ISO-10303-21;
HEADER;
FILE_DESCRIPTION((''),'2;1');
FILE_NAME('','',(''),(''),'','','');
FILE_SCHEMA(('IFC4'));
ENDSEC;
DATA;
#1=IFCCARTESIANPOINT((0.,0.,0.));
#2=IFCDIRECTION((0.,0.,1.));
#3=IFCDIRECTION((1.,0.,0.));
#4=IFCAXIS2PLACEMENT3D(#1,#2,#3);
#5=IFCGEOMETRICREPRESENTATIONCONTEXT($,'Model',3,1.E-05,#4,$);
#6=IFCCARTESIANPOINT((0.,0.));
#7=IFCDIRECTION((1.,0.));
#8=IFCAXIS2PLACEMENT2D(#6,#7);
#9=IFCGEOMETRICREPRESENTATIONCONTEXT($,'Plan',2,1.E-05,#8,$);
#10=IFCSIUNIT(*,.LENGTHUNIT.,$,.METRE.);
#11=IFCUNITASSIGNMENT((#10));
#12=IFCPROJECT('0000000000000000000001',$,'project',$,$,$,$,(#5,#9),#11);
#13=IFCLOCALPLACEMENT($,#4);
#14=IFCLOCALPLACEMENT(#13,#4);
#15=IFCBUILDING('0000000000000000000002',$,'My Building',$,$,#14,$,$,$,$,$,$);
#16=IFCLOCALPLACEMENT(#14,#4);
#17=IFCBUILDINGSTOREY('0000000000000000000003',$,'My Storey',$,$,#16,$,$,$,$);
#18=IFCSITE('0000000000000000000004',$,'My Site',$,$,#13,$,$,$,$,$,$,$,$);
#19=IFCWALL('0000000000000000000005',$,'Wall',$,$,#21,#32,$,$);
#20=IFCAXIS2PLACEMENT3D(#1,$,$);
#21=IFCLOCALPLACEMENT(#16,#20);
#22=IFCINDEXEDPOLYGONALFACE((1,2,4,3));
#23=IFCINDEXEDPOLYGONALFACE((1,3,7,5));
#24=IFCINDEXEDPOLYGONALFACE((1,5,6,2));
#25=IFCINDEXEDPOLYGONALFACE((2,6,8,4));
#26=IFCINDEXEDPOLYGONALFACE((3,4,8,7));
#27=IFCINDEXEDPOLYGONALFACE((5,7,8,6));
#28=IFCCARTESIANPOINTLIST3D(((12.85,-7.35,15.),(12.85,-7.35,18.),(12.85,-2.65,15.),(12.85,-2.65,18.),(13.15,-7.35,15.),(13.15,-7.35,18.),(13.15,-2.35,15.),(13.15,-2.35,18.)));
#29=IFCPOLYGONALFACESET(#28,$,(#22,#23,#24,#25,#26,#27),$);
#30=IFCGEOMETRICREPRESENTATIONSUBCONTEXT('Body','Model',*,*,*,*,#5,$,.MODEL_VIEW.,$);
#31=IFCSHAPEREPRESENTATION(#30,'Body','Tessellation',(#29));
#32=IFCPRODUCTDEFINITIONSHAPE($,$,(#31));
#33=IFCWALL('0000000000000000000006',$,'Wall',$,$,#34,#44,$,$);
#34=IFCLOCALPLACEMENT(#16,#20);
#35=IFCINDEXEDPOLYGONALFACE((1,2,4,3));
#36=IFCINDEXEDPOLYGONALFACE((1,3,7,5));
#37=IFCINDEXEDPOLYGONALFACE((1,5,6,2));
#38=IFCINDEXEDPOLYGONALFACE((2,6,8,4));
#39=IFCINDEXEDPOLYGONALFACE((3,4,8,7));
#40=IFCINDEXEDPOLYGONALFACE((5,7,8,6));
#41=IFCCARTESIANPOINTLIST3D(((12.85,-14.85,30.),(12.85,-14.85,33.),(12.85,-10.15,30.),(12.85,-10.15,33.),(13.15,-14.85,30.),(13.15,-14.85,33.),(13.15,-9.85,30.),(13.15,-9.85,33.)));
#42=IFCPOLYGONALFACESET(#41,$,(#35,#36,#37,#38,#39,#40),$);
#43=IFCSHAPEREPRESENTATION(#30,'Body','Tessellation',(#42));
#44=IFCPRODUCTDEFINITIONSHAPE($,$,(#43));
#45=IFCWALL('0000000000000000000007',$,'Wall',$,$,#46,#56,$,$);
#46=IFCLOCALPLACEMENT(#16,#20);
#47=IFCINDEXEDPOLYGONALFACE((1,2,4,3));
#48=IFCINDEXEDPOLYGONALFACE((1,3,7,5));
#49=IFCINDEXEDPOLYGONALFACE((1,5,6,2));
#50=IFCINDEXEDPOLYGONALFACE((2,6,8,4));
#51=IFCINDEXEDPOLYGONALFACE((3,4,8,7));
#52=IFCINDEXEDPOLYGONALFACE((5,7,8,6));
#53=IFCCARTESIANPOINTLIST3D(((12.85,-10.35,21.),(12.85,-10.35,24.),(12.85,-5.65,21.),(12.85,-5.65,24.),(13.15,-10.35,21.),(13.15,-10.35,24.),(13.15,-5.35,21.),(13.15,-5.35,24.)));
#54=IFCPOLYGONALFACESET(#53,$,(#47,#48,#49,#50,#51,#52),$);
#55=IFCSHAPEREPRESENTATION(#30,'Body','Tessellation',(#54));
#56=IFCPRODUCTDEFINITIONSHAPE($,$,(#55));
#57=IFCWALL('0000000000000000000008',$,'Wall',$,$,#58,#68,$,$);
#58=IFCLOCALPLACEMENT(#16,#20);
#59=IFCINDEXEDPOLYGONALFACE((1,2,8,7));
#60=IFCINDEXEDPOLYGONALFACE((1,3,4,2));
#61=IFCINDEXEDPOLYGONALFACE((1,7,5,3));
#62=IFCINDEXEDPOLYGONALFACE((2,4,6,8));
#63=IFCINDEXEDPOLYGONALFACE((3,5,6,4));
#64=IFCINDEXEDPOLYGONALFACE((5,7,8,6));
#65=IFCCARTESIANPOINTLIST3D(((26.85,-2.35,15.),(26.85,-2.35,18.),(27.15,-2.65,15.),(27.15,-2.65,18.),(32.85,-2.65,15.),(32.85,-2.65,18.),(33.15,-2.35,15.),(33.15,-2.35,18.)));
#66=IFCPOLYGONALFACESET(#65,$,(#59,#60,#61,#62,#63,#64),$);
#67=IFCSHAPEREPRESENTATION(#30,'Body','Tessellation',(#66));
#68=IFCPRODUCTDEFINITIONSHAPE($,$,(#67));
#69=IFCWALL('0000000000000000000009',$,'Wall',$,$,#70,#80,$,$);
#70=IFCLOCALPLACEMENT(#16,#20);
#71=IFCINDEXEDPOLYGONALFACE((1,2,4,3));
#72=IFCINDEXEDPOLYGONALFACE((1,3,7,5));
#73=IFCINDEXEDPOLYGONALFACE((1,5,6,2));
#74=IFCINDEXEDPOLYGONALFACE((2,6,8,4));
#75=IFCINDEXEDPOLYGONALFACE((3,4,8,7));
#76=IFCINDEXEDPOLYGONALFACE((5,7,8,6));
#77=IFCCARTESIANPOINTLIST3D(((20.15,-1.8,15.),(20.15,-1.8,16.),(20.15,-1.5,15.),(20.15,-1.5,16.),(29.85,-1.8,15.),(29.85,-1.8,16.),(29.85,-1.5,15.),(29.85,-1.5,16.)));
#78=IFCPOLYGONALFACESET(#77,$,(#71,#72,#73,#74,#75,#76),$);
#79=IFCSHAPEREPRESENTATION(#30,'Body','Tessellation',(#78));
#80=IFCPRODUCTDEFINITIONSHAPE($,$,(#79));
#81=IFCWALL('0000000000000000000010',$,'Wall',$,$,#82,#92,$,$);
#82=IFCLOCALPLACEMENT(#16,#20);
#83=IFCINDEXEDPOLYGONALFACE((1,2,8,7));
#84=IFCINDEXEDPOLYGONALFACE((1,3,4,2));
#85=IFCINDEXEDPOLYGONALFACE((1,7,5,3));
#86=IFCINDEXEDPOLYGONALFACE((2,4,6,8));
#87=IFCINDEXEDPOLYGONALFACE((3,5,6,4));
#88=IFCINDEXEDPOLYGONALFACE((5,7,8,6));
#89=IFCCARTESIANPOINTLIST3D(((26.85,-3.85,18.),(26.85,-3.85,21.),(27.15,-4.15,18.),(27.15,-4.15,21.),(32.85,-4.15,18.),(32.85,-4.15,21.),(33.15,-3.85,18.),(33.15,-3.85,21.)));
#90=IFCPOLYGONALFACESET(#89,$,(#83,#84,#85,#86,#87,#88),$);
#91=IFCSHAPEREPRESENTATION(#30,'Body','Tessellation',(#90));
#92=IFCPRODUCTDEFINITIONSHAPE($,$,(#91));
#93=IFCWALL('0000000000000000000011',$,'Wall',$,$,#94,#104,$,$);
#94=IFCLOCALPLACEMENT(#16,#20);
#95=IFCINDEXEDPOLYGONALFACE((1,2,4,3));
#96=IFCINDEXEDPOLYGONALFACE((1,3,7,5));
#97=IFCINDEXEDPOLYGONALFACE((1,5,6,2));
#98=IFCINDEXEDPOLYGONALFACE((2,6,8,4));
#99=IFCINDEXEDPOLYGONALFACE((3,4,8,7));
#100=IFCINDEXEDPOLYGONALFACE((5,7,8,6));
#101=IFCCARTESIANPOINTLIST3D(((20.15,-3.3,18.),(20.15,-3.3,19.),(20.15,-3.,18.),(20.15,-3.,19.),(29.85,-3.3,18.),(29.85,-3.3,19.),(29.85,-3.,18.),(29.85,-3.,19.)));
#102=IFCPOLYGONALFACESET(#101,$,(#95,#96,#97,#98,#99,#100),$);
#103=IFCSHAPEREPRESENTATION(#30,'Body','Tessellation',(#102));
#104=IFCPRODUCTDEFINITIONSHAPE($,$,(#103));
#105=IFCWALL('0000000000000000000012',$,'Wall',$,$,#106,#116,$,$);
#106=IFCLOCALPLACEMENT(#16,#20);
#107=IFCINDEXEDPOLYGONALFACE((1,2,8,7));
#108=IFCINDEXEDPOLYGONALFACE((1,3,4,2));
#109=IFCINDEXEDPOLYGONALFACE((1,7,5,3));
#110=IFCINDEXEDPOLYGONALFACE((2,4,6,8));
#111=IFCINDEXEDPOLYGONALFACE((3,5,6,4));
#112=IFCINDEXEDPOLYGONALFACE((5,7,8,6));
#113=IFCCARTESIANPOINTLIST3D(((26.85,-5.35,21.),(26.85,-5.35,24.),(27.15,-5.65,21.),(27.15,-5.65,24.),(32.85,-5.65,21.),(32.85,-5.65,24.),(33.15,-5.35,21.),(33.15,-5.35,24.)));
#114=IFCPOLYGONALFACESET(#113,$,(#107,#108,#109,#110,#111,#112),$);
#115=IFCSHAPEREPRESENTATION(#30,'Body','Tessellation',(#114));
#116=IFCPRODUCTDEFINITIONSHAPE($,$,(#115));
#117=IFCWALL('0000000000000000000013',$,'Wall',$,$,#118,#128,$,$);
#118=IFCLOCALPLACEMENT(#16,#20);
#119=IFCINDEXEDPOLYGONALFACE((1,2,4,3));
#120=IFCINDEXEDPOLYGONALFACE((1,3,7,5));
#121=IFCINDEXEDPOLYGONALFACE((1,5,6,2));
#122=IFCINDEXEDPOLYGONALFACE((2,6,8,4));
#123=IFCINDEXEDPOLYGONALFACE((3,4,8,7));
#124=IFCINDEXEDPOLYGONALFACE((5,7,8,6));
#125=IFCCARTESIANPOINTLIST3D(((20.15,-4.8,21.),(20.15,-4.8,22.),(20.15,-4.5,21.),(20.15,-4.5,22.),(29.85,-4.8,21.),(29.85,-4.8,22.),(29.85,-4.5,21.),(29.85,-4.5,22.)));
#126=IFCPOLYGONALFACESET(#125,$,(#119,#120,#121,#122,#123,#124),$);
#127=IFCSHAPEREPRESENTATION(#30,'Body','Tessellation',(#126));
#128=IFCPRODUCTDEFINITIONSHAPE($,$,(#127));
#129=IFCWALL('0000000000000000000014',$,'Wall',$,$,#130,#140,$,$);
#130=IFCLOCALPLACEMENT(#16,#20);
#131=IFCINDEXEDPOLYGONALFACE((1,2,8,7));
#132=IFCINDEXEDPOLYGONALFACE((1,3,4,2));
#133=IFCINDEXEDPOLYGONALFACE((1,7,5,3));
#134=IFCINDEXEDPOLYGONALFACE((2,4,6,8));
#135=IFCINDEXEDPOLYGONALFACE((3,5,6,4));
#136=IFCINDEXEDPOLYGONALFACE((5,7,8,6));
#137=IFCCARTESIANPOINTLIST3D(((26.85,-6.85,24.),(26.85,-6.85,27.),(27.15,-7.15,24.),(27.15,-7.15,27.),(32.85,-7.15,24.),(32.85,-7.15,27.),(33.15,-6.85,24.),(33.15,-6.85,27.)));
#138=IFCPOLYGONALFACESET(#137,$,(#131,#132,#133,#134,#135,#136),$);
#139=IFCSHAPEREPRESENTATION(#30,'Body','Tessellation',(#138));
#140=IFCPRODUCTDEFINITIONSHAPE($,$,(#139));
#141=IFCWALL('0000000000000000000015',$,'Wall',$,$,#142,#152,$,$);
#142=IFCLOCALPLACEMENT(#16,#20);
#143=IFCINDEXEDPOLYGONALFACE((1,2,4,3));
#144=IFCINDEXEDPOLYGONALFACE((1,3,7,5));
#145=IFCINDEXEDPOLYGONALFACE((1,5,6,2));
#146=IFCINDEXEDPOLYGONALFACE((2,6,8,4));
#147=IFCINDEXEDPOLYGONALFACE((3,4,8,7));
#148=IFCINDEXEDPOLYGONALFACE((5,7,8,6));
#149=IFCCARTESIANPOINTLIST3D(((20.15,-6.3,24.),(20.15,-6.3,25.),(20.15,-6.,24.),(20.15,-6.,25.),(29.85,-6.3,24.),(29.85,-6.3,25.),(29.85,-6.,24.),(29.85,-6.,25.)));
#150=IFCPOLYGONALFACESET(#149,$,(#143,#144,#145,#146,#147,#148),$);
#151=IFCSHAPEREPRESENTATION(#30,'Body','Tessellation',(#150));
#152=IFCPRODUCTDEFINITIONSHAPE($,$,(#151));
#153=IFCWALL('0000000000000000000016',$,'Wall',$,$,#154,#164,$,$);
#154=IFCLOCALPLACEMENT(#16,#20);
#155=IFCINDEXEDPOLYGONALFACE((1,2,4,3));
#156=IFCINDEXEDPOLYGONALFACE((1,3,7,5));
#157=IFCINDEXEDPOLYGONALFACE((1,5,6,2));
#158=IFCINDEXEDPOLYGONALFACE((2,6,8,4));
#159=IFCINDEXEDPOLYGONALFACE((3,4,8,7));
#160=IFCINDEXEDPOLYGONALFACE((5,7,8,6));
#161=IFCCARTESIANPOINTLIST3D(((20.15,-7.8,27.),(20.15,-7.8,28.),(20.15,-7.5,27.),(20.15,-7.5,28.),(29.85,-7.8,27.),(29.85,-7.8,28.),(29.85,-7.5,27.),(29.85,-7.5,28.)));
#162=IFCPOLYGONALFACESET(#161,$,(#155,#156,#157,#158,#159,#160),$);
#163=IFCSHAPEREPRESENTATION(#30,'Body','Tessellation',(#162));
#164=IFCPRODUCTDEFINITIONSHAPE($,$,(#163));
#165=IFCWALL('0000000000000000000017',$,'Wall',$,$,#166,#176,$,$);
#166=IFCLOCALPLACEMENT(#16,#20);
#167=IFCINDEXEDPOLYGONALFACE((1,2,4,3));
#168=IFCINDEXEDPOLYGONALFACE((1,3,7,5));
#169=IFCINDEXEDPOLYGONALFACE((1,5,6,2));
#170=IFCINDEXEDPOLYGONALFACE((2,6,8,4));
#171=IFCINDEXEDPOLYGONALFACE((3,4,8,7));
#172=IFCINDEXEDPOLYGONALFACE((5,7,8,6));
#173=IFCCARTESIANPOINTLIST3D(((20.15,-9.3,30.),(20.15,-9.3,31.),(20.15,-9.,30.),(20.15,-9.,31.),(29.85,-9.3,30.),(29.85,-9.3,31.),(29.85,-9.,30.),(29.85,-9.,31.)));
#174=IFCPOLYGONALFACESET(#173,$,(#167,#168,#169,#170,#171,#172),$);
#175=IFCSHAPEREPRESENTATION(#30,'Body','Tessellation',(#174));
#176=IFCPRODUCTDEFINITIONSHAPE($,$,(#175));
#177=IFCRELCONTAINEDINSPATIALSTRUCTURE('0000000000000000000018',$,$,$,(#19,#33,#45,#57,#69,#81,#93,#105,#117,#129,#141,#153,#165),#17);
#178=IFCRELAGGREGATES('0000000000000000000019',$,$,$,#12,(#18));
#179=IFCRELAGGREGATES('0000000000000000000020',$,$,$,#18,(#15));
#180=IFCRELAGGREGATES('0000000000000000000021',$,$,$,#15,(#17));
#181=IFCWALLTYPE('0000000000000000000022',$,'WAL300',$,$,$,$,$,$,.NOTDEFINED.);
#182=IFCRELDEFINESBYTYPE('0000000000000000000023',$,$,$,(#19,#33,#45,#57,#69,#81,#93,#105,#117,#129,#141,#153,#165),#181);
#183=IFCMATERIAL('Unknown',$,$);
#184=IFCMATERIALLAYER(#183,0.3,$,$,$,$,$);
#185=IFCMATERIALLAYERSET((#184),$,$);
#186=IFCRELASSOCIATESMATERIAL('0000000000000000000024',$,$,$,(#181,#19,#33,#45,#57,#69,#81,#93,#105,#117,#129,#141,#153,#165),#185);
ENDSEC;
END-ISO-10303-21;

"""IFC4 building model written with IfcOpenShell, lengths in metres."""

from ifc_helpers import new_model, si_unit, frame, origin_with_axes, origin_2d_with_axis, place, context, subcontext, project, spatial, line, indexed_curve, outline, extrude, material, layer, layer_set, layer_usage, type_object, element, save


model = new_model("IFC4")

# Units and contexts
model_context = context("Model", 3, precision=1e-05, world=origin_with_axes())
plan_context = context("Plan", 2, precision=1e-05, world=origin_2d_with_axis())
body_context = subcontext(model_context, "Body", "Model", "MODEL_VIEW")
ifc_project = project(units=[si_unit("LENGTHUNIT", "METRE")], contexts=[model_context, plan_context])

# Site, building, storey
site_placement = place(None, origin_with_axes())
site = spatial("IfcSite", under=ifc_project, at=site_placement, Name="My Site")
building_placement = place(site_placement, origin_with_axes())
building = spatial("IfcBuilding", under=site, at=building_placement, Name="My Building")
storey_placement = place(building_placement, origin_with_axes())
storey = spatial("IfcBuildingStorey", under=building, at=storey_placement, Name="My Storey")

# Walls
ifc_material = material(Name="Unknown")
ifc_layer = layer(ifc_material, 0.3)
ifc_layer_set = layer_set([ifc_layer])
wall_type = type_object("IfcWallType", Name="WAL300", PredefinedType="NOTDEFINED", material=ifc_layer_set)
ifc_layer_usage_1 = layer_usage(ifc_layer_set, "AXIS2", "POSITIVE", -0.15)
wall_1_placement = place(storey_placement, frame((13.0, -7.5, 15.0), z_axis=(0.0, 0.0, 1.0), x_axis=(0.0, 1.0, 0.0)))
element("IfcWall", 1, at=wall_1_placement, inside=storey, type_object=wall_type, material=ifc_layer_usage_1, Name="Wall", context=body_context, shape_type="SweptSolid", body=[
    extrude(outline(indexed_curve([(0.15, -0.15), (0.15, 0.15), (4.85, 0.15), (5.15, -0.15)], segments=[line(1, 2, 3, 4, 1)])), origin_with_axes(), (0.0, 0.0, 1.0), 3.0),
])
ifc_layer_usage_2 = layer_usage(ifc_layer_set, "AXIS2", "POSITIVE", -0.15)
wall_2_placement = place(storey_placement, frame((13.0, -15.0, 30.0), z_axis=(0.0, 0.0, 1.0), x_axis=(0.0, 1.0, 0.0)))
element("IfcWall", 2, at=wall_2_placement, inside=storey, type_object=wall_type, material=ifc_layer_usage_2, Name="Wall", context=body_context, shape_type="SweptSolid", body=[
    extrude(outline(indexed_curve([(0.15, -0.15), (0.15, 0.15), (4.85, 0.15), (5.15, -0.15)], segments=[line(1, 2, 3, 4, 1)])), origin_with_axes(), (0.0, 0.0, 1.0), 3.0),
])
ifc_layer_usage_3 = layer_usage(ifc_layer_set, "AXIS2", "POSITIVE", -0.15)
wall_3_placement = place(storey_placement, frame((13.0, -10.5, 21.0), z_axis=(0.0, 0.0, 1.0), x_axis=(0.0, 1.0, 0.0)))
element("IfcWall", 3, at=wall_3_placement, inside=storey, type_object=wall_type, material=ifc_layer_usage_3, Name="Wall", context=body_context, shape_type="SweptSolid", body=[
    extrude(outline(indexed_curve([(0.15, -0.15), (0.15, 0.15), (4.85, 0.15), (5.15, -0.15)], segments=[line(1, 2, 3, 4, 1)])), origin_with_axes(), (0.0, 0.0, 1.0), 3.0),
])
ifc_layer_usage_4 = layer_usage(ifc_layer_set, "AXIS2", "POSITIVE", -0.15)
wall_4_placement = place(storey_placement, frame((27.0, -2.5, 15.0), z_axis=(0.0, 0.0, 1.0), x_axis=(1.0, 0.0, 0.0)))
element("IfcWall", 4, at=wall_4_placement, inside=storey, type_object=wall_type, material=ifc_layer_usage_4, Name="Wall", context=body_context, shape_type="SweptSolid", body=[
    extrude(outline(indexed_curve([(0.15, -0.15), (-0.15, 0.15), (6.15, 0.15), (5.85, -0.15)], segments=[line(1, 2, 3, 4, 1)])), origin_with_axes(), (0.0, 0.0, 1.0), 3.0),
])
ifc_layer_usage_5 = layer_usage(ifc_layer_set, "AXIS2", "POSITIVE", -0.3)
wall_5_placement = place(storey_placement, frame((20.15, -1.5, 15.0), z_axis=(0.0, 0.0, 1.0), x_axis=(1.0, 0.0, 0.0)))
element("IfcWall", 5, at=wall_5_placement, inside=storey, type_object=wall_type, material=ifc_layer_usage_5, Name="Wall", context=body_context, shape_type="SweptSolid", body=[
    extrude(outline(indexed_curve([(0.0, -0.3), (0.0, 0.0), (9.7, 0.0), (9.7, -0.3)], segments=[line(1, 2, 3, 4, 1)])), origin_with_axes(), (0.0, 0.0, 1.0), 1.0),
])
ifc_layer_usage_6 = layer_usage(ifc_layer_set, "AXIS2", "POSITIVE", -0.15)
wall_6_placement = place(storey_placement, frame((27.0, -4.0, 18.0), z_axis=(0.0, 0.0, 1.0), x_axis=(1.0, 0.0, 0.0)))
element("IfcWall", 6, at=wall_6_placement, inside=storey, type_object=wall_type, material=ifc_layer_usage_6, Name="Wall", context=body_context, shape_type="SweptSolid", body=[
    extrude(outline(indexed_curve([(0.15, -0.15), (-0.15, 0.15), (6.15, 0.15), (5.85, -0.15)], segments=[line(1, 2, 3, 4, 1)])), origin_with_axes(), (0.0, 0.0, 1.0), 3.0),
])
ifc_layer_usage_7 = layer_usage(ifc_layer_set, "AXIS2", "POSITIVE", -0.3)
wall_7_placement = place(storey_placement, frame((20.15, -3.0, 18.0), z_axis=(0.0, 0.0, 1.0), x_axis=(1.0, 0.0, 0.0)))
element("IfcWall", 7, at=wall_7_placement, inside=storey, type_object=wall_type, material=ifc_layer_usage_7, Name="Wall", context=body_context, shape_type="SweptSolid", body=[
    extrude(outline(indexed_curve([(0.0, -0.3), (0.0, 0.0), (9.7, 0.0), (9.7, -0.3)], segments=[line(1, 2, 3, 4, 1)])), origin_with_axes(), (0.0, 0.0, 1.0), 1.0),
])
ifc_layer_usage_8 = layer_usage(ifc_layer_set, "AXIS2", "POSITIVE", -0.15)
wall_8_placement = place(storey_placement, frame((27.0, -5.5, 21.0), z_axis=(0.0, 0.0, 1.0), x_axis=(1.0, 0.0, 0.0)))
element("IfcWall", 8, at=wall_8_placement, inside=storey, type_object=wall_type, material=ifc_layer_usage_8, Name="Wall", context=body_context, shape_type="SweptSolid", body=[
    extrude(outline(indexed_curve([(0.15, -0.15), (-0.15, 0.15), (6.15, 0.15), (5.85, -0.15)], segments=[line(1, 2, 3, 4, 1)])), origin_with_axes(), (0.0, 0.0, 1.0), 3.0),
])
ifc_layer_usage_9 = layer_usage(ifc_layer_set, "AXIS2", "POSITIVE", -0.3)
wall_9_placement = place(storey_placement, frame((20.15, -4.5, 21.0), z_axis=(0.0, 0.0, 1.0), x_axis=(1.0, 0.0, 0.0)))
element("IfcWall", 9, at=wall_9_placement, inside=storey, type_object=wall_type, material=ifc_layer_usage_9, Name="Wall", context=body_context, shape_type="SweptSolid", body=[
    extrude(outline(indexed_curve([(0.0, -0.3), (0.0, 0.0), (9.7, 0.0), (9.7, -0.3)], segments=[line(1, 2, 3, 4, 1)])), origin_with_axes(), (0.0, 0.0, 1.0), 1.0),
])
ifc_layer_usage_10 = layer_usage(ifc_layer_set, "AXIS2", "POSITIVE", -0.15)
wall_10_placement = place(storey_placement, frame((27.0, -7.0, 24.0), z_axis=(0.0, 0.0, 1.0), x_axis=(1.0, 0.0, 0.0)))
element("IfcWall", 10, at=wall_10_placement, inside=storey, type_object=wall_type, material=ifc_layer_usage_10, Name="Wall", context=body_context, shape_type="SweptSolid", body=[
    extrude(outline(indexed_curve([(0.15, -0.15), (-0.15, 0.15), (6.15, 0.15), (5.85, -0.15)], segments=[line(1, 2, 3, 4, 1)])), origin_with_axes(), (0.0, 0.0, 1.0), 3.0),
])
ifc_layer_usage_11 = layer_usage(ifc_layer_set, "AXIS2", "POSITIVE", -0.3)
wall_11_placement = place(storey_placement, frame((20.15, -6.0, 24.0), z_axis=(0.0, 0.0, 1.0), x_axis=(1.0, 0.0, 0.0)))
element("IfcWall", 11, at=wall_11_placement, inside=storey, type_object=wall_type, material=ifc_layer_usage_11, Name="Wall", context=body_context, shape_type="SweptSolid", body=[
    extrude(outline(indexed_curve([(0.0, -0.3), (0.0, 0.0), (9.7, 0.0), (9.7, -0.3)], segments=[line(1, 2, 3, 4, 1)])), origin_with_axes(), (0.0, 0.0, 1.0), 1.0),
])
ifc_layer_usage_12 = layer_usage(ifc_layer_set, "AXIS2", "POSITIVE", -0.3)
wall_12_placement = place(storey_placement, frame((20.15, -7.5, 27.0), z_axis=(0.0, 0.0, 1.0), x_axis=(1.0, 0.0, 0.0)))
element("IfcWall", 12, at=wall_12_placement, inside=storey, type_object=wall_type, material=ifc_layer_usage_12, Name="Wall", context=body_context, shape_type="SweptSolid", body=[
    extrude(outline(indexed_curve([(0.0, -0.3), (0.0, 0.0), (9.7, 0.0), (9.7, -0.3)], segments=[line(1, 2, 3, 4, 1)])), origin_with_axes(), (0.0, 0.0, 1.0), 1.0),
])
ifc_layer_usage_13 = layer_usage(ifc_layer_set, "AXIS2", "POSITIVE", -0.3)
wall_13_placement = place(storey_placement, frame((20.15, -9.0, 30.0), z_axis=(0.0, 0.0, 1.0), x_axis=(1.0, 0.0, 0.0)))
element("IfcWall", 13, at=wall_13_placement, inside=storey, type_object=wall_type, material=ifc_layer_usage_13, Name="Wall", context=body_context, shape_type="SweptSolid", body=[
    extrude(outline(indexed_curve([(0.0, -0.3), (0.0, 0.0), (9.7, 0.0), (9.7, -0.3)], segments=[line(1, 2, 3, 4, 1)])), origin_with_axes(), (0.0, 0.0, 1.0), 1.0),
])

save(model, "model.ifc")
